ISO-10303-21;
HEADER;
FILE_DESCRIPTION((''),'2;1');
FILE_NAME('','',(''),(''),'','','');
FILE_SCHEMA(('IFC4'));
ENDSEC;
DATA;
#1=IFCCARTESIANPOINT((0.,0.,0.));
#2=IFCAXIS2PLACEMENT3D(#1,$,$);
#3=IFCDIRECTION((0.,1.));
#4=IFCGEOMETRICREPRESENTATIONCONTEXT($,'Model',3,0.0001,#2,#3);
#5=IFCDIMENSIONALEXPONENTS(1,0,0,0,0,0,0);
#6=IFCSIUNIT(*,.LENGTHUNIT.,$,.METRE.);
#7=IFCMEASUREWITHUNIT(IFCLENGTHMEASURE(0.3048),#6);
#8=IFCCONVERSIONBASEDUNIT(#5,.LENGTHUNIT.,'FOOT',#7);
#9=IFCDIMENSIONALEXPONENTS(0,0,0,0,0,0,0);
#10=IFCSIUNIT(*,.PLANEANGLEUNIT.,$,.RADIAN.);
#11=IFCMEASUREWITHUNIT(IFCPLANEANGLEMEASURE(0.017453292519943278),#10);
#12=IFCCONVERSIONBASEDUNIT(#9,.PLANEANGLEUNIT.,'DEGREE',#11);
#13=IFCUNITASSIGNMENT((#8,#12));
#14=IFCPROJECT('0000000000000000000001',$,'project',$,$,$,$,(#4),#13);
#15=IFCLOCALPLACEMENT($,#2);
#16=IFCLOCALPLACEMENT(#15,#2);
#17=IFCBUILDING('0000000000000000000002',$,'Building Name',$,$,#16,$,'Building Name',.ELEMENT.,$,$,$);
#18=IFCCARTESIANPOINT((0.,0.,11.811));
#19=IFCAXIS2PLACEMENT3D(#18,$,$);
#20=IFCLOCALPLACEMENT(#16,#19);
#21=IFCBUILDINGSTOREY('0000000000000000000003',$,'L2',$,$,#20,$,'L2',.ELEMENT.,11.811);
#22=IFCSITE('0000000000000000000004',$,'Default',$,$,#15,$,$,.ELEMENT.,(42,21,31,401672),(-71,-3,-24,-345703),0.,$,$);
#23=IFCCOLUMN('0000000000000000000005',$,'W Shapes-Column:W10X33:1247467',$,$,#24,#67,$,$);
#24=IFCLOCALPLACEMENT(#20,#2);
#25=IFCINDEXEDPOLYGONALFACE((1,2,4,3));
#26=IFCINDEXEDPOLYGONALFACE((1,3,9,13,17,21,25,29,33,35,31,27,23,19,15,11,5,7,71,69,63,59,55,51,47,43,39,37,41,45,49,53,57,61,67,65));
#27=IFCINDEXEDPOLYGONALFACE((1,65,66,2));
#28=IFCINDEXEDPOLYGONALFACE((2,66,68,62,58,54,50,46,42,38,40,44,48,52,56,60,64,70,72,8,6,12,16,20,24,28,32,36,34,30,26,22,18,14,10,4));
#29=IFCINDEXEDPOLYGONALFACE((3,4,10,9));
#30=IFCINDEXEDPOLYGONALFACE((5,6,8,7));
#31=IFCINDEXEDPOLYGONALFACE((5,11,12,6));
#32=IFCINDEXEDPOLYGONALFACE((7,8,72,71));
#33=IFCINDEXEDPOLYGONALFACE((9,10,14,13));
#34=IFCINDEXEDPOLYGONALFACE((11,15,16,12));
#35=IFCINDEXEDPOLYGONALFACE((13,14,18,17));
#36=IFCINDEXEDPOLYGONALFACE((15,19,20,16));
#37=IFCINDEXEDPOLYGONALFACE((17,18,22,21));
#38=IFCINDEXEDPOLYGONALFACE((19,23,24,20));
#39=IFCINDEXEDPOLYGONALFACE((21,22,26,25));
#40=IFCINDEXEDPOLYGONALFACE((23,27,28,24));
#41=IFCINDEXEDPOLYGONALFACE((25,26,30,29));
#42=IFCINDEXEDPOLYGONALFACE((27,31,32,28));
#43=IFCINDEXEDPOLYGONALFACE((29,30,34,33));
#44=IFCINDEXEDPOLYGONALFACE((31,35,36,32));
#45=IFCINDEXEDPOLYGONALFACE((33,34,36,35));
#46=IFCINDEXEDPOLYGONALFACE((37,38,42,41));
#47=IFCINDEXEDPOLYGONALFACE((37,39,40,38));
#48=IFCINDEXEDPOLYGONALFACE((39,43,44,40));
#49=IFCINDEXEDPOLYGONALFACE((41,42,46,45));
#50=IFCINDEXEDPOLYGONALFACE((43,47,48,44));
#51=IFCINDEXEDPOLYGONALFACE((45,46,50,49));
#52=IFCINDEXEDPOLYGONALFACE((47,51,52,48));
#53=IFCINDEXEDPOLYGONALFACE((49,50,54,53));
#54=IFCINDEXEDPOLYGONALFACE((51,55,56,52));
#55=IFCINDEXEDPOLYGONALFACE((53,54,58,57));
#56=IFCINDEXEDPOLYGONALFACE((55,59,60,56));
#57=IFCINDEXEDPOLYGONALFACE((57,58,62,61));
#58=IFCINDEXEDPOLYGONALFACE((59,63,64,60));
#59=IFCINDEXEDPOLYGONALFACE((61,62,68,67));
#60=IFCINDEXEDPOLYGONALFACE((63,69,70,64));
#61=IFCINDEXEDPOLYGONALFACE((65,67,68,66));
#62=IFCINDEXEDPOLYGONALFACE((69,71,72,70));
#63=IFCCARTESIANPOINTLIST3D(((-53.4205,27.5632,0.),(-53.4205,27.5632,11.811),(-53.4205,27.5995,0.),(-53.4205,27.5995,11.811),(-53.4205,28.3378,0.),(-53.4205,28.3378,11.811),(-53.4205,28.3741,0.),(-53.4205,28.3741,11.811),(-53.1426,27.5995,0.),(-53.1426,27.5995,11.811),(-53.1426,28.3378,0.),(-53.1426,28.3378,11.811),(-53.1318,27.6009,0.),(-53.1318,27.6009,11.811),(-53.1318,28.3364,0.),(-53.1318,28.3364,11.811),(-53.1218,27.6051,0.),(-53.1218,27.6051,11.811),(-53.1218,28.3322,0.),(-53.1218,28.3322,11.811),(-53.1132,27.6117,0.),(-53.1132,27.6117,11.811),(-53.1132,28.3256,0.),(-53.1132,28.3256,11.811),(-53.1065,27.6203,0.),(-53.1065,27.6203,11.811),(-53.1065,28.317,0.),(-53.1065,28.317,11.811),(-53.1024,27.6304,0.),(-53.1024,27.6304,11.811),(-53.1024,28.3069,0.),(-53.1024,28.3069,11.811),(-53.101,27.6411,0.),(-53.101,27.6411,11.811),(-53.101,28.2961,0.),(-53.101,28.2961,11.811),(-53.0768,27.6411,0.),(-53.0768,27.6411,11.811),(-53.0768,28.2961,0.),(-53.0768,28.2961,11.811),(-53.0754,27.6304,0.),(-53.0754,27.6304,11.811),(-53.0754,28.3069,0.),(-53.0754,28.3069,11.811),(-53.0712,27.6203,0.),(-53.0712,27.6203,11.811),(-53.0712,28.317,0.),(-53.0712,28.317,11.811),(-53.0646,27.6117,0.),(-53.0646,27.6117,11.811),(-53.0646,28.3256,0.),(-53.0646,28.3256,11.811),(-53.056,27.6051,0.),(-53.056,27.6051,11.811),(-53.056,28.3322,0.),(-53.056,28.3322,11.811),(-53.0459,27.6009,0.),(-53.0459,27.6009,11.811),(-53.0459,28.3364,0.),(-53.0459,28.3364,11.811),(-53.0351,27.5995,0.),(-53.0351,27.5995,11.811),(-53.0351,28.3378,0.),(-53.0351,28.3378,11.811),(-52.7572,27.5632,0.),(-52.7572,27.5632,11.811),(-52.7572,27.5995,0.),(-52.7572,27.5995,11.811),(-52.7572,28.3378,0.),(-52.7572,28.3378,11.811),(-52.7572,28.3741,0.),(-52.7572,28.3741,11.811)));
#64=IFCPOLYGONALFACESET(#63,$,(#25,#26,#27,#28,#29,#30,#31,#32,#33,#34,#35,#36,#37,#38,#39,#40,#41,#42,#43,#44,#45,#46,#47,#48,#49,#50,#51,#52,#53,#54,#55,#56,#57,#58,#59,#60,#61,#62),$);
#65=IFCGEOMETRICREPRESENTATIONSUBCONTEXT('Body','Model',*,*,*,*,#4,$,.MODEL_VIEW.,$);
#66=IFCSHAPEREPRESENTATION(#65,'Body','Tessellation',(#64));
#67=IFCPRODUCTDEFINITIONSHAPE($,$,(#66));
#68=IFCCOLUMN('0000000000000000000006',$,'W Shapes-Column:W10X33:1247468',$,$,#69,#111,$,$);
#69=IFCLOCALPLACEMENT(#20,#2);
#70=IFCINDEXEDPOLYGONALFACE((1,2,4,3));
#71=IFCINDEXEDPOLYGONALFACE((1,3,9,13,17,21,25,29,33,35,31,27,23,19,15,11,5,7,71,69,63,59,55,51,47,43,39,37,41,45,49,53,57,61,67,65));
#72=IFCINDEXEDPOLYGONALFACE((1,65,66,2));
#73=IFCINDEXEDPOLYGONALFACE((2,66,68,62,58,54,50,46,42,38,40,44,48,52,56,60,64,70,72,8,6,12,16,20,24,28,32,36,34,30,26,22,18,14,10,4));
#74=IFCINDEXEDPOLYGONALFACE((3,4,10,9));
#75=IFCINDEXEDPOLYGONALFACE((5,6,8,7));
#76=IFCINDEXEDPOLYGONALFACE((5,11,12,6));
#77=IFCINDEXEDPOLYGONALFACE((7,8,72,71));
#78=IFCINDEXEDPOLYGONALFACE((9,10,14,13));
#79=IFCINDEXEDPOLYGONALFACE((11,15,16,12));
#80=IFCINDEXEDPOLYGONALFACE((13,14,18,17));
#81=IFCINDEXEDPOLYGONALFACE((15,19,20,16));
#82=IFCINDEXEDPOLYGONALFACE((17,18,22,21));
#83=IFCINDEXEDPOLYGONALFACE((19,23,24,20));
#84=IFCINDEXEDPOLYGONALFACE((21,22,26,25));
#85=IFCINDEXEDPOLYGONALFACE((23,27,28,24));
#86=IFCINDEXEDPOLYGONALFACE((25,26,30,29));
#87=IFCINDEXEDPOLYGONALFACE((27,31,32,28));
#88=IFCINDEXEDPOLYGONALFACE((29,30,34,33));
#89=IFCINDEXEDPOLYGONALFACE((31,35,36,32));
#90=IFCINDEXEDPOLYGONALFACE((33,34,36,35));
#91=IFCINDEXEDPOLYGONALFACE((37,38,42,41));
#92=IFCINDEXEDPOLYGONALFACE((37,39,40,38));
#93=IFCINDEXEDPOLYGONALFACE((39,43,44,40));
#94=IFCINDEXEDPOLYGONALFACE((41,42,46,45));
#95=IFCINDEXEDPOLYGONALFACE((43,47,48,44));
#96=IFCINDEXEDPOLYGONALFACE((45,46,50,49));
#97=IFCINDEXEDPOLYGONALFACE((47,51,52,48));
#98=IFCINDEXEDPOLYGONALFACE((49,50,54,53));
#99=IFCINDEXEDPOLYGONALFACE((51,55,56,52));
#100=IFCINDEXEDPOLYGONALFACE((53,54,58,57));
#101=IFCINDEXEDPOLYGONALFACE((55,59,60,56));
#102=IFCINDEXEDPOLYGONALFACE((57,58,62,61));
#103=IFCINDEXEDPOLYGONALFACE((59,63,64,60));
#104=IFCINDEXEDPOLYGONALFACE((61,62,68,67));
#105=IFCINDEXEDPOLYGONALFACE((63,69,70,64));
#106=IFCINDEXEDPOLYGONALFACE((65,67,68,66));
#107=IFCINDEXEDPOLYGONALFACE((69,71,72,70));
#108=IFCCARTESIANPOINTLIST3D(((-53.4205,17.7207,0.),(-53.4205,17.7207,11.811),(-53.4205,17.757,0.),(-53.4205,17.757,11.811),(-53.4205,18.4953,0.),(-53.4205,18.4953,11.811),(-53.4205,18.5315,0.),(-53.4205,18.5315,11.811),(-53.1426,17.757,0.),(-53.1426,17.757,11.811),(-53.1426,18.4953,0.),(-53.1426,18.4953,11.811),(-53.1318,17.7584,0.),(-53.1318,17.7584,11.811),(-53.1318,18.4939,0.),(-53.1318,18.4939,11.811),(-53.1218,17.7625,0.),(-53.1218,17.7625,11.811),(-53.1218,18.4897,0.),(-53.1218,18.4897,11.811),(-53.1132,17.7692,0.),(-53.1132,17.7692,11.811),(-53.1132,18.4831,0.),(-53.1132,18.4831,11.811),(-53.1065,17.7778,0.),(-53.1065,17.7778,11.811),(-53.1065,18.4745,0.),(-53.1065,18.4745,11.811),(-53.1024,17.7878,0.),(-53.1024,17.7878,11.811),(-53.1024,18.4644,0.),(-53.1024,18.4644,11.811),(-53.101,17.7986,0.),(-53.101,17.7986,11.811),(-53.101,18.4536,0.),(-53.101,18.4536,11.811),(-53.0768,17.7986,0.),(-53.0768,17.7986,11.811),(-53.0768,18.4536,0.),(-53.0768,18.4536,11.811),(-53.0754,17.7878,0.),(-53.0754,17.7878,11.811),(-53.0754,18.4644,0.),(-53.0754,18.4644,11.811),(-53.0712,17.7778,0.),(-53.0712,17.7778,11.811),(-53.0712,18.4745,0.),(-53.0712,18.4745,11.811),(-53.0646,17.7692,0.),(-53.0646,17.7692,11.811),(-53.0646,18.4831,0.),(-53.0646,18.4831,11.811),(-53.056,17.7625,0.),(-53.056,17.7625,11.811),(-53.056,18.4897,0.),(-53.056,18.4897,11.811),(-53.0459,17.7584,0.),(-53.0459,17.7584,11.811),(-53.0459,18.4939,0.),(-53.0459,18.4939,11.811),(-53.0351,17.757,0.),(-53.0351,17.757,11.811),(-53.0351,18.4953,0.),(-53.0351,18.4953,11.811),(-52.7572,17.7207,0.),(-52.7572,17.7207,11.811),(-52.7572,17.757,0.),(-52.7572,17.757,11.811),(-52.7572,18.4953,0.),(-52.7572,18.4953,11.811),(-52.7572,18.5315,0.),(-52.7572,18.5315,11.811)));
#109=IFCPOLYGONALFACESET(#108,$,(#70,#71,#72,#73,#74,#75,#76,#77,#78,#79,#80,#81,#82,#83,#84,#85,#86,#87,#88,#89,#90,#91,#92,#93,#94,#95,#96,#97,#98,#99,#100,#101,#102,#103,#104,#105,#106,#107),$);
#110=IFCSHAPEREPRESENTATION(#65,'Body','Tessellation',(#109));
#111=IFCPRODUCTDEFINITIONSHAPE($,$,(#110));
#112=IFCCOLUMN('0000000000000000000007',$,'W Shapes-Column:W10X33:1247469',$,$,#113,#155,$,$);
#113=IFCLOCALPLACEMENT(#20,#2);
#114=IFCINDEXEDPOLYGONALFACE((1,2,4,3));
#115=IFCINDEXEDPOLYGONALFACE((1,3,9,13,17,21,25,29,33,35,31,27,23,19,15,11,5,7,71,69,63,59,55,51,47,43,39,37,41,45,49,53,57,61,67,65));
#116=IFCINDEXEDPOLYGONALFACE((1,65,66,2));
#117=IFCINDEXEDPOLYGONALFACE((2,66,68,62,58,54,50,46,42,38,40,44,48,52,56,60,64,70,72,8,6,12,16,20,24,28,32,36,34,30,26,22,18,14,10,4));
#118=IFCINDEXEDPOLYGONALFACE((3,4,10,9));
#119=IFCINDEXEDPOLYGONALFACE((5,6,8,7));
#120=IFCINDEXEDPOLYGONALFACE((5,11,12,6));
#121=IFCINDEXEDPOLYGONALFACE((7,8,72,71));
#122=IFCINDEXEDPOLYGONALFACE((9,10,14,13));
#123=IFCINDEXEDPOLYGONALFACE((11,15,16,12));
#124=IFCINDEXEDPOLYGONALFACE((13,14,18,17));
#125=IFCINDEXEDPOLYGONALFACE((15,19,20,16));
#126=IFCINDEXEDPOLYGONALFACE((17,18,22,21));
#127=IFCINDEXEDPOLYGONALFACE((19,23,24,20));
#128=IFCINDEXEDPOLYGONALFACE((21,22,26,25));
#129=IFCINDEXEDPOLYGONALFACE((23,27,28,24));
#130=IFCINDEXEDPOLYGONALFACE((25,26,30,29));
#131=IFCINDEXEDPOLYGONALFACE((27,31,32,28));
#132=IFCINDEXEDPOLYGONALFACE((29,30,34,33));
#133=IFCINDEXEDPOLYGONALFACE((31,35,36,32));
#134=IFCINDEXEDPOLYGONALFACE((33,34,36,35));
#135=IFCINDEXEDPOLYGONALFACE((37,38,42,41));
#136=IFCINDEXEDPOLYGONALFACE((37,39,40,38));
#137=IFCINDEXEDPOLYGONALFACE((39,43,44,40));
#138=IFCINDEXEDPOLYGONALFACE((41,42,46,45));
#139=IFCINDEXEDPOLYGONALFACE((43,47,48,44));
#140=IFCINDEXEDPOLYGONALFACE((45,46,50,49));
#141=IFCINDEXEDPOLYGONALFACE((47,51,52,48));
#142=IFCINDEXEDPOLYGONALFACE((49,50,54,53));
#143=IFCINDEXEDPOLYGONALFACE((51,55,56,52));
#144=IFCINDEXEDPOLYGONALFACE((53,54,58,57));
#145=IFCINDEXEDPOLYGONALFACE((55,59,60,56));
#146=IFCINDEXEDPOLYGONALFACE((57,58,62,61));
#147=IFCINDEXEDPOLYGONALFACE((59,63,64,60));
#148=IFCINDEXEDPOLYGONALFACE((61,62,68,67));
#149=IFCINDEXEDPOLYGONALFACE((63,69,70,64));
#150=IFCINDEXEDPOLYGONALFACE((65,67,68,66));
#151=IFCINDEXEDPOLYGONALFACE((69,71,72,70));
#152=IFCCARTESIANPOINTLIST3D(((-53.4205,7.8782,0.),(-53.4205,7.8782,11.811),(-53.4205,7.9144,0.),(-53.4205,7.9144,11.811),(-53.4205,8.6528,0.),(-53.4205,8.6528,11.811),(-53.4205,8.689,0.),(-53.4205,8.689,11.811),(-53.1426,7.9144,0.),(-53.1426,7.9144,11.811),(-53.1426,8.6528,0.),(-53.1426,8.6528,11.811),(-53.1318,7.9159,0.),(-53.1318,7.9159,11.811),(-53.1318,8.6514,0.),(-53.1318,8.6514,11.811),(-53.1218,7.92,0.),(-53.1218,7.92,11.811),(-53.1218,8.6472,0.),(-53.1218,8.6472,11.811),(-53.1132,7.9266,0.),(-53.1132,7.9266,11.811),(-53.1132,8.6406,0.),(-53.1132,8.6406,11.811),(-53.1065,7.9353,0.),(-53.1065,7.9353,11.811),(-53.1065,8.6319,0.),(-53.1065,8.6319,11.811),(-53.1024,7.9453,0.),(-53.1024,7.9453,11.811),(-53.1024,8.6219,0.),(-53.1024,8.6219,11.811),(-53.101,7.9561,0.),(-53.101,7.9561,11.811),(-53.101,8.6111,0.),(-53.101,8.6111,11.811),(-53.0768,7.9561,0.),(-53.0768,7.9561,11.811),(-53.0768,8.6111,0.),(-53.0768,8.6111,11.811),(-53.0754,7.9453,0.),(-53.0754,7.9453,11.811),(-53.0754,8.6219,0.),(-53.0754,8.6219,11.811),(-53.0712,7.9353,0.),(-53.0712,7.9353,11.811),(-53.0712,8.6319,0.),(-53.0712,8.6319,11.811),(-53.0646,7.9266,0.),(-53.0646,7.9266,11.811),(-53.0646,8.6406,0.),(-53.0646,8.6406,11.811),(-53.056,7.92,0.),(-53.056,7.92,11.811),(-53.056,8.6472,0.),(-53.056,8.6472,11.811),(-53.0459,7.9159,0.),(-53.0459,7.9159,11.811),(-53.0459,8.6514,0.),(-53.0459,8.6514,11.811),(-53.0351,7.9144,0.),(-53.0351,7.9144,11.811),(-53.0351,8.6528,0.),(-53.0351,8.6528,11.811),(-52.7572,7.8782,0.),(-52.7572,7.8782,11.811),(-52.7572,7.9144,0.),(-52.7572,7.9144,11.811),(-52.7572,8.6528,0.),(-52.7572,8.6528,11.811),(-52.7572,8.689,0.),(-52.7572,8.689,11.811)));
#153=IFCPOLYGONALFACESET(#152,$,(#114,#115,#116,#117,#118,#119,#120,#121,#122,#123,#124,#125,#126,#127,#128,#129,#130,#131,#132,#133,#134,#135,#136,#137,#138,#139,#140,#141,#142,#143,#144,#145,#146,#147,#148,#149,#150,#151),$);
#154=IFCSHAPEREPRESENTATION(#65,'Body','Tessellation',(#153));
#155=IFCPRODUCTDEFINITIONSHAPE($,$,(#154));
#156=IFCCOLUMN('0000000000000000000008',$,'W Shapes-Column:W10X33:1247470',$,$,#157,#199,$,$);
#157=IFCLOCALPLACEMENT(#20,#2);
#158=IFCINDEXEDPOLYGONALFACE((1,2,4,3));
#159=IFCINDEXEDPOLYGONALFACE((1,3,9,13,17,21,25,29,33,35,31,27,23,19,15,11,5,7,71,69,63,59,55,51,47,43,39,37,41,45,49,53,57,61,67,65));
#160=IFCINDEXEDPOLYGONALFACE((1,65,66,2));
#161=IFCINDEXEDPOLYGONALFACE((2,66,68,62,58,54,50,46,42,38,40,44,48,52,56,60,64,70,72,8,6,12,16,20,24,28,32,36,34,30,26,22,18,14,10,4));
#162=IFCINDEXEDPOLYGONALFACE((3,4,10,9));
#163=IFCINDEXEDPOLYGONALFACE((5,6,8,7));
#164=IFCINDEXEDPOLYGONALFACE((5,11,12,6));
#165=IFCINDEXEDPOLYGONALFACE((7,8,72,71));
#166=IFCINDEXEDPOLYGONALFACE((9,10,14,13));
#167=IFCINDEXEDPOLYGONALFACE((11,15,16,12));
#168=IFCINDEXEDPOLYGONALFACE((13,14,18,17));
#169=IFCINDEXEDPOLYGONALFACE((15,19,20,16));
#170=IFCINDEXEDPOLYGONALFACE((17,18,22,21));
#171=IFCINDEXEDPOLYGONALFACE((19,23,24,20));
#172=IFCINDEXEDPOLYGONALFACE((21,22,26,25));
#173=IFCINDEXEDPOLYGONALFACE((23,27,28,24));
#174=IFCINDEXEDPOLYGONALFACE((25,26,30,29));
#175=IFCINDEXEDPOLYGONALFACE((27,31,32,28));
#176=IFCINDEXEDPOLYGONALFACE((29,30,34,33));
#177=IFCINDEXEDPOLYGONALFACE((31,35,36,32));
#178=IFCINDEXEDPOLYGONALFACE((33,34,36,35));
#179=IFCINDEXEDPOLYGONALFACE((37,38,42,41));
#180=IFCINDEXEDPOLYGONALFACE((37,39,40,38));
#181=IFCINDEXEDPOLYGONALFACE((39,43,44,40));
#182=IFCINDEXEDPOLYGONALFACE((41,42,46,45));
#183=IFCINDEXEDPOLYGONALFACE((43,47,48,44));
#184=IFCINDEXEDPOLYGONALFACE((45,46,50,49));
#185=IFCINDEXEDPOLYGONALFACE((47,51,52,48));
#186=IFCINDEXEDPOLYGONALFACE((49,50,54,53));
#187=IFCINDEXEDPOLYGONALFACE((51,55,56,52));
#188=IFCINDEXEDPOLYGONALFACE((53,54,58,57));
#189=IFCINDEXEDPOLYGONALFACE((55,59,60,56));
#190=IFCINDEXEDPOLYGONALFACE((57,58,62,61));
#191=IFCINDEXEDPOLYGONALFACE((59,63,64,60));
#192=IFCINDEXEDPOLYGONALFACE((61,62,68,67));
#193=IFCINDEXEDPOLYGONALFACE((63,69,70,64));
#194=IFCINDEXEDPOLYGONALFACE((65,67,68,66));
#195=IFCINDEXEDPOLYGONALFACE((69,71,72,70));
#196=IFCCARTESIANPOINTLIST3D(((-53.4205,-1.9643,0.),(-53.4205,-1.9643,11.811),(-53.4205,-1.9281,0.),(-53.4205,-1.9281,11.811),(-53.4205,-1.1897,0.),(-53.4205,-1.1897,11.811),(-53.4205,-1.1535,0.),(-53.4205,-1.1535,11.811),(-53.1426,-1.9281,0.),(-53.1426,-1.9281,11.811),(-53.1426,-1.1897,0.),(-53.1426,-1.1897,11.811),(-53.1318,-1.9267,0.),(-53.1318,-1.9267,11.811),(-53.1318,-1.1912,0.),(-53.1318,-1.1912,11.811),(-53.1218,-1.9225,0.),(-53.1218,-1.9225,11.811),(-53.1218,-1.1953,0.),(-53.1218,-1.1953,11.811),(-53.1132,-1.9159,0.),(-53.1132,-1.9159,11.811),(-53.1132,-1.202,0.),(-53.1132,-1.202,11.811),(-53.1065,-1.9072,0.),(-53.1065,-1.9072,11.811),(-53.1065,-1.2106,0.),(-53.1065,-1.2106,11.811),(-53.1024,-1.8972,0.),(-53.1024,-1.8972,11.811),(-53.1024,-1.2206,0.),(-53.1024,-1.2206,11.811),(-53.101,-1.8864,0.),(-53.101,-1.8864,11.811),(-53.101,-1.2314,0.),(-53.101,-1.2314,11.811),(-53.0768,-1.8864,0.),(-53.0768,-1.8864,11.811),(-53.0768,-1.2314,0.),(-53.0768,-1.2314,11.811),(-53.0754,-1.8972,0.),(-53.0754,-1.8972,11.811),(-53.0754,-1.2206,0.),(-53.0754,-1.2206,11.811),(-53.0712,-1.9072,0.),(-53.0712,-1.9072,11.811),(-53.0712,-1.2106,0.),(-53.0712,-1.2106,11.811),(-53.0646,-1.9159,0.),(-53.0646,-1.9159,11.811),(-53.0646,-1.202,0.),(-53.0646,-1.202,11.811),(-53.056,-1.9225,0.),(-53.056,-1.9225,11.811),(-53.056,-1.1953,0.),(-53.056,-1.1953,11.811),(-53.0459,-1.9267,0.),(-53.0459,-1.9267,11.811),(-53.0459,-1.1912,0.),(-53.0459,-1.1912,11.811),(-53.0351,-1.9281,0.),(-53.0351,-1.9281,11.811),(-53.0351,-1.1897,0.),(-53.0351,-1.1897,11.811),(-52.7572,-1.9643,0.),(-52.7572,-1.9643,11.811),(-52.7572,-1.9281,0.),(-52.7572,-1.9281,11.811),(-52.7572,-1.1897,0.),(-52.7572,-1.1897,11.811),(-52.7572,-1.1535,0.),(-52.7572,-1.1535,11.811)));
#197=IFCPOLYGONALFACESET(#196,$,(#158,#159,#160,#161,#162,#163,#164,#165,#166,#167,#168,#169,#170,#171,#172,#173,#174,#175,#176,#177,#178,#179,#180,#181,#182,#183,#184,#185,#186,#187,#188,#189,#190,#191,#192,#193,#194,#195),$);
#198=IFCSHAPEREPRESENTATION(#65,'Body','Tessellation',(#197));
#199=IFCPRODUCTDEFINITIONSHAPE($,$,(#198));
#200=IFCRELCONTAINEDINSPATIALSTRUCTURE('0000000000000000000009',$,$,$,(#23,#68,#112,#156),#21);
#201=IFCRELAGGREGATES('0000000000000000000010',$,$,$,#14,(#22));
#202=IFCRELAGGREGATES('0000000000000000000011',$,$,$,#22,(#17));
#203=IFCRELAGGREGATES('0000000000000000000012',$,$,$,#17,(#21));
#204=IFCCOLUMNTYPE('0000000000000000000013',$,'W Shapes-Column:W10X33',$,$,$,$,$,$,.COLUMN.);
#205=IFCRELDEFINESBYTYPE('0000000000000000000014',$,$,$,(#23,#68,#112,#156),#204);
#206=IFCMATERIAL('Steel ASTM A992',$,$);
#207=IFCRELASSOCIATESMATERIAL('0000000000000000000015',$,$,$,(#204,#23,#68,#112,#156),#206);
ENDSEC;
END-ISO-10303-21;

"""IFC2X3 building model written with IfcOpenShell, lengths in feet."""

from ifc_helpers import new_model, entity, si_unit, converted_unit, direction, frame, frame_2d, origin, place, context, subcontext, project, spatial, i_section, extrude, source, transform, mapped, material, type_object, type_shapes, element, save


model = new_model("IFC2X3")

# Units and contexts
model_context = context("Model", 3, precision=0.0001, world=origin(), true_north=direction((0.0, 1.0)))
body_context = subcontext(model_context, "Body", "Model", "MODEL_VIEW")
ifc_project = project(units=[converted_unit("LENGTHUNIT", "FOOT", entity("IfcLengthMeasure", 0.3048), si_unit("LENGTHUNIT", "METRE"), dimensions=[1, 0, 0, 0, 0, 0, 0]), converted_unit("PLANEANGLEUNIT", "DEGREE", entity("IfcPlaneAngleMeasure", 0.017453292519943278), si_unit("PLANEANGLEUNIT", "RADIAN"), dimensions=[0, 0, 0, 0, 0, 0, 0])], contexts=[model_context])

# Site, building, storey
site_placement = place(None, origin())
site = spatial("IfcSite", under=ifc_project, at=site_placement, Name="Default", CompositionType="ELEMENT", RefLatitude=(42, 21, 31, 401672), RefLongitude=(-71, -3, -24, -345703), RefElevation=0.0)
building_placement = place(site_placement, origin())
building = spatial("IfcBuilding", under=site, at=building_placement, Name="Building Name", LongName="Building Name", CompositionType="ELEMENT")
storey_placement = place(building_placement, frame((0.0, 0.0, 11.811)))
storey = spatial("IfcBuildingStorey", under=building, at=storey_placement, Name="L2", LongName="L2", CompositionType="ELEMENT", Elevation=11.811)

# Columns
ifc_material_1 = material(Name="Steel ASTM A992")
column_type = type_object("IfcColumnType", Name="W Shapes-Column:W10X33", PredefinedType="COLUMN", material=ifc_material_1)
shared_shape = source(origin(), body_context, "Body", "SweptSolid", [
    extrude(i_section(OverallWidth=0.6633, OverallDepth=0.8108, WebThickness=0.0242, FlangeThickness=0.0362, FilletRadius=0.0417, at=frame_2d((0.0, 0.0), x_axis=(1.0, 0.0))), frame((0.0, 0.0, 11.811), z_axis=(0.0, 0.0, 1.0), x_axis=(-1.0, 0.0, 0.0)), (0.0, 0.0, 1.0), 11.811),
])
type_shapes(column_type, [shared_shape])
for number, where, name in (
    (1, (-53.0889, 27.9686, -11.811), "W Shapes-Column:W10X33:1247467"),
    (2, (-53.0889, 18.1261, -11.811), "W Shapes-Column:W10X33:1247468"),
    (3, (-53.0889, 8.2836, -11.811), "W Shapes-Column:W10X33:1247469"),
    (4, (-53.0889, -1.5589, -11.811), "W Shapes-Column:W10X33:1247470"),
):
    element("IfcColumn", number, at=place(storey_placement, frame(where)), inside=storey, type_object=column_type, material=ifc_material_1, Name=name, context=body_context, shape_type="MappedRepresentation", body=[
        mapped(shared_shape, transform((0.0, 0.0, 0.0), scale=1.0)),
    ])

save(model, "model.ifc")
